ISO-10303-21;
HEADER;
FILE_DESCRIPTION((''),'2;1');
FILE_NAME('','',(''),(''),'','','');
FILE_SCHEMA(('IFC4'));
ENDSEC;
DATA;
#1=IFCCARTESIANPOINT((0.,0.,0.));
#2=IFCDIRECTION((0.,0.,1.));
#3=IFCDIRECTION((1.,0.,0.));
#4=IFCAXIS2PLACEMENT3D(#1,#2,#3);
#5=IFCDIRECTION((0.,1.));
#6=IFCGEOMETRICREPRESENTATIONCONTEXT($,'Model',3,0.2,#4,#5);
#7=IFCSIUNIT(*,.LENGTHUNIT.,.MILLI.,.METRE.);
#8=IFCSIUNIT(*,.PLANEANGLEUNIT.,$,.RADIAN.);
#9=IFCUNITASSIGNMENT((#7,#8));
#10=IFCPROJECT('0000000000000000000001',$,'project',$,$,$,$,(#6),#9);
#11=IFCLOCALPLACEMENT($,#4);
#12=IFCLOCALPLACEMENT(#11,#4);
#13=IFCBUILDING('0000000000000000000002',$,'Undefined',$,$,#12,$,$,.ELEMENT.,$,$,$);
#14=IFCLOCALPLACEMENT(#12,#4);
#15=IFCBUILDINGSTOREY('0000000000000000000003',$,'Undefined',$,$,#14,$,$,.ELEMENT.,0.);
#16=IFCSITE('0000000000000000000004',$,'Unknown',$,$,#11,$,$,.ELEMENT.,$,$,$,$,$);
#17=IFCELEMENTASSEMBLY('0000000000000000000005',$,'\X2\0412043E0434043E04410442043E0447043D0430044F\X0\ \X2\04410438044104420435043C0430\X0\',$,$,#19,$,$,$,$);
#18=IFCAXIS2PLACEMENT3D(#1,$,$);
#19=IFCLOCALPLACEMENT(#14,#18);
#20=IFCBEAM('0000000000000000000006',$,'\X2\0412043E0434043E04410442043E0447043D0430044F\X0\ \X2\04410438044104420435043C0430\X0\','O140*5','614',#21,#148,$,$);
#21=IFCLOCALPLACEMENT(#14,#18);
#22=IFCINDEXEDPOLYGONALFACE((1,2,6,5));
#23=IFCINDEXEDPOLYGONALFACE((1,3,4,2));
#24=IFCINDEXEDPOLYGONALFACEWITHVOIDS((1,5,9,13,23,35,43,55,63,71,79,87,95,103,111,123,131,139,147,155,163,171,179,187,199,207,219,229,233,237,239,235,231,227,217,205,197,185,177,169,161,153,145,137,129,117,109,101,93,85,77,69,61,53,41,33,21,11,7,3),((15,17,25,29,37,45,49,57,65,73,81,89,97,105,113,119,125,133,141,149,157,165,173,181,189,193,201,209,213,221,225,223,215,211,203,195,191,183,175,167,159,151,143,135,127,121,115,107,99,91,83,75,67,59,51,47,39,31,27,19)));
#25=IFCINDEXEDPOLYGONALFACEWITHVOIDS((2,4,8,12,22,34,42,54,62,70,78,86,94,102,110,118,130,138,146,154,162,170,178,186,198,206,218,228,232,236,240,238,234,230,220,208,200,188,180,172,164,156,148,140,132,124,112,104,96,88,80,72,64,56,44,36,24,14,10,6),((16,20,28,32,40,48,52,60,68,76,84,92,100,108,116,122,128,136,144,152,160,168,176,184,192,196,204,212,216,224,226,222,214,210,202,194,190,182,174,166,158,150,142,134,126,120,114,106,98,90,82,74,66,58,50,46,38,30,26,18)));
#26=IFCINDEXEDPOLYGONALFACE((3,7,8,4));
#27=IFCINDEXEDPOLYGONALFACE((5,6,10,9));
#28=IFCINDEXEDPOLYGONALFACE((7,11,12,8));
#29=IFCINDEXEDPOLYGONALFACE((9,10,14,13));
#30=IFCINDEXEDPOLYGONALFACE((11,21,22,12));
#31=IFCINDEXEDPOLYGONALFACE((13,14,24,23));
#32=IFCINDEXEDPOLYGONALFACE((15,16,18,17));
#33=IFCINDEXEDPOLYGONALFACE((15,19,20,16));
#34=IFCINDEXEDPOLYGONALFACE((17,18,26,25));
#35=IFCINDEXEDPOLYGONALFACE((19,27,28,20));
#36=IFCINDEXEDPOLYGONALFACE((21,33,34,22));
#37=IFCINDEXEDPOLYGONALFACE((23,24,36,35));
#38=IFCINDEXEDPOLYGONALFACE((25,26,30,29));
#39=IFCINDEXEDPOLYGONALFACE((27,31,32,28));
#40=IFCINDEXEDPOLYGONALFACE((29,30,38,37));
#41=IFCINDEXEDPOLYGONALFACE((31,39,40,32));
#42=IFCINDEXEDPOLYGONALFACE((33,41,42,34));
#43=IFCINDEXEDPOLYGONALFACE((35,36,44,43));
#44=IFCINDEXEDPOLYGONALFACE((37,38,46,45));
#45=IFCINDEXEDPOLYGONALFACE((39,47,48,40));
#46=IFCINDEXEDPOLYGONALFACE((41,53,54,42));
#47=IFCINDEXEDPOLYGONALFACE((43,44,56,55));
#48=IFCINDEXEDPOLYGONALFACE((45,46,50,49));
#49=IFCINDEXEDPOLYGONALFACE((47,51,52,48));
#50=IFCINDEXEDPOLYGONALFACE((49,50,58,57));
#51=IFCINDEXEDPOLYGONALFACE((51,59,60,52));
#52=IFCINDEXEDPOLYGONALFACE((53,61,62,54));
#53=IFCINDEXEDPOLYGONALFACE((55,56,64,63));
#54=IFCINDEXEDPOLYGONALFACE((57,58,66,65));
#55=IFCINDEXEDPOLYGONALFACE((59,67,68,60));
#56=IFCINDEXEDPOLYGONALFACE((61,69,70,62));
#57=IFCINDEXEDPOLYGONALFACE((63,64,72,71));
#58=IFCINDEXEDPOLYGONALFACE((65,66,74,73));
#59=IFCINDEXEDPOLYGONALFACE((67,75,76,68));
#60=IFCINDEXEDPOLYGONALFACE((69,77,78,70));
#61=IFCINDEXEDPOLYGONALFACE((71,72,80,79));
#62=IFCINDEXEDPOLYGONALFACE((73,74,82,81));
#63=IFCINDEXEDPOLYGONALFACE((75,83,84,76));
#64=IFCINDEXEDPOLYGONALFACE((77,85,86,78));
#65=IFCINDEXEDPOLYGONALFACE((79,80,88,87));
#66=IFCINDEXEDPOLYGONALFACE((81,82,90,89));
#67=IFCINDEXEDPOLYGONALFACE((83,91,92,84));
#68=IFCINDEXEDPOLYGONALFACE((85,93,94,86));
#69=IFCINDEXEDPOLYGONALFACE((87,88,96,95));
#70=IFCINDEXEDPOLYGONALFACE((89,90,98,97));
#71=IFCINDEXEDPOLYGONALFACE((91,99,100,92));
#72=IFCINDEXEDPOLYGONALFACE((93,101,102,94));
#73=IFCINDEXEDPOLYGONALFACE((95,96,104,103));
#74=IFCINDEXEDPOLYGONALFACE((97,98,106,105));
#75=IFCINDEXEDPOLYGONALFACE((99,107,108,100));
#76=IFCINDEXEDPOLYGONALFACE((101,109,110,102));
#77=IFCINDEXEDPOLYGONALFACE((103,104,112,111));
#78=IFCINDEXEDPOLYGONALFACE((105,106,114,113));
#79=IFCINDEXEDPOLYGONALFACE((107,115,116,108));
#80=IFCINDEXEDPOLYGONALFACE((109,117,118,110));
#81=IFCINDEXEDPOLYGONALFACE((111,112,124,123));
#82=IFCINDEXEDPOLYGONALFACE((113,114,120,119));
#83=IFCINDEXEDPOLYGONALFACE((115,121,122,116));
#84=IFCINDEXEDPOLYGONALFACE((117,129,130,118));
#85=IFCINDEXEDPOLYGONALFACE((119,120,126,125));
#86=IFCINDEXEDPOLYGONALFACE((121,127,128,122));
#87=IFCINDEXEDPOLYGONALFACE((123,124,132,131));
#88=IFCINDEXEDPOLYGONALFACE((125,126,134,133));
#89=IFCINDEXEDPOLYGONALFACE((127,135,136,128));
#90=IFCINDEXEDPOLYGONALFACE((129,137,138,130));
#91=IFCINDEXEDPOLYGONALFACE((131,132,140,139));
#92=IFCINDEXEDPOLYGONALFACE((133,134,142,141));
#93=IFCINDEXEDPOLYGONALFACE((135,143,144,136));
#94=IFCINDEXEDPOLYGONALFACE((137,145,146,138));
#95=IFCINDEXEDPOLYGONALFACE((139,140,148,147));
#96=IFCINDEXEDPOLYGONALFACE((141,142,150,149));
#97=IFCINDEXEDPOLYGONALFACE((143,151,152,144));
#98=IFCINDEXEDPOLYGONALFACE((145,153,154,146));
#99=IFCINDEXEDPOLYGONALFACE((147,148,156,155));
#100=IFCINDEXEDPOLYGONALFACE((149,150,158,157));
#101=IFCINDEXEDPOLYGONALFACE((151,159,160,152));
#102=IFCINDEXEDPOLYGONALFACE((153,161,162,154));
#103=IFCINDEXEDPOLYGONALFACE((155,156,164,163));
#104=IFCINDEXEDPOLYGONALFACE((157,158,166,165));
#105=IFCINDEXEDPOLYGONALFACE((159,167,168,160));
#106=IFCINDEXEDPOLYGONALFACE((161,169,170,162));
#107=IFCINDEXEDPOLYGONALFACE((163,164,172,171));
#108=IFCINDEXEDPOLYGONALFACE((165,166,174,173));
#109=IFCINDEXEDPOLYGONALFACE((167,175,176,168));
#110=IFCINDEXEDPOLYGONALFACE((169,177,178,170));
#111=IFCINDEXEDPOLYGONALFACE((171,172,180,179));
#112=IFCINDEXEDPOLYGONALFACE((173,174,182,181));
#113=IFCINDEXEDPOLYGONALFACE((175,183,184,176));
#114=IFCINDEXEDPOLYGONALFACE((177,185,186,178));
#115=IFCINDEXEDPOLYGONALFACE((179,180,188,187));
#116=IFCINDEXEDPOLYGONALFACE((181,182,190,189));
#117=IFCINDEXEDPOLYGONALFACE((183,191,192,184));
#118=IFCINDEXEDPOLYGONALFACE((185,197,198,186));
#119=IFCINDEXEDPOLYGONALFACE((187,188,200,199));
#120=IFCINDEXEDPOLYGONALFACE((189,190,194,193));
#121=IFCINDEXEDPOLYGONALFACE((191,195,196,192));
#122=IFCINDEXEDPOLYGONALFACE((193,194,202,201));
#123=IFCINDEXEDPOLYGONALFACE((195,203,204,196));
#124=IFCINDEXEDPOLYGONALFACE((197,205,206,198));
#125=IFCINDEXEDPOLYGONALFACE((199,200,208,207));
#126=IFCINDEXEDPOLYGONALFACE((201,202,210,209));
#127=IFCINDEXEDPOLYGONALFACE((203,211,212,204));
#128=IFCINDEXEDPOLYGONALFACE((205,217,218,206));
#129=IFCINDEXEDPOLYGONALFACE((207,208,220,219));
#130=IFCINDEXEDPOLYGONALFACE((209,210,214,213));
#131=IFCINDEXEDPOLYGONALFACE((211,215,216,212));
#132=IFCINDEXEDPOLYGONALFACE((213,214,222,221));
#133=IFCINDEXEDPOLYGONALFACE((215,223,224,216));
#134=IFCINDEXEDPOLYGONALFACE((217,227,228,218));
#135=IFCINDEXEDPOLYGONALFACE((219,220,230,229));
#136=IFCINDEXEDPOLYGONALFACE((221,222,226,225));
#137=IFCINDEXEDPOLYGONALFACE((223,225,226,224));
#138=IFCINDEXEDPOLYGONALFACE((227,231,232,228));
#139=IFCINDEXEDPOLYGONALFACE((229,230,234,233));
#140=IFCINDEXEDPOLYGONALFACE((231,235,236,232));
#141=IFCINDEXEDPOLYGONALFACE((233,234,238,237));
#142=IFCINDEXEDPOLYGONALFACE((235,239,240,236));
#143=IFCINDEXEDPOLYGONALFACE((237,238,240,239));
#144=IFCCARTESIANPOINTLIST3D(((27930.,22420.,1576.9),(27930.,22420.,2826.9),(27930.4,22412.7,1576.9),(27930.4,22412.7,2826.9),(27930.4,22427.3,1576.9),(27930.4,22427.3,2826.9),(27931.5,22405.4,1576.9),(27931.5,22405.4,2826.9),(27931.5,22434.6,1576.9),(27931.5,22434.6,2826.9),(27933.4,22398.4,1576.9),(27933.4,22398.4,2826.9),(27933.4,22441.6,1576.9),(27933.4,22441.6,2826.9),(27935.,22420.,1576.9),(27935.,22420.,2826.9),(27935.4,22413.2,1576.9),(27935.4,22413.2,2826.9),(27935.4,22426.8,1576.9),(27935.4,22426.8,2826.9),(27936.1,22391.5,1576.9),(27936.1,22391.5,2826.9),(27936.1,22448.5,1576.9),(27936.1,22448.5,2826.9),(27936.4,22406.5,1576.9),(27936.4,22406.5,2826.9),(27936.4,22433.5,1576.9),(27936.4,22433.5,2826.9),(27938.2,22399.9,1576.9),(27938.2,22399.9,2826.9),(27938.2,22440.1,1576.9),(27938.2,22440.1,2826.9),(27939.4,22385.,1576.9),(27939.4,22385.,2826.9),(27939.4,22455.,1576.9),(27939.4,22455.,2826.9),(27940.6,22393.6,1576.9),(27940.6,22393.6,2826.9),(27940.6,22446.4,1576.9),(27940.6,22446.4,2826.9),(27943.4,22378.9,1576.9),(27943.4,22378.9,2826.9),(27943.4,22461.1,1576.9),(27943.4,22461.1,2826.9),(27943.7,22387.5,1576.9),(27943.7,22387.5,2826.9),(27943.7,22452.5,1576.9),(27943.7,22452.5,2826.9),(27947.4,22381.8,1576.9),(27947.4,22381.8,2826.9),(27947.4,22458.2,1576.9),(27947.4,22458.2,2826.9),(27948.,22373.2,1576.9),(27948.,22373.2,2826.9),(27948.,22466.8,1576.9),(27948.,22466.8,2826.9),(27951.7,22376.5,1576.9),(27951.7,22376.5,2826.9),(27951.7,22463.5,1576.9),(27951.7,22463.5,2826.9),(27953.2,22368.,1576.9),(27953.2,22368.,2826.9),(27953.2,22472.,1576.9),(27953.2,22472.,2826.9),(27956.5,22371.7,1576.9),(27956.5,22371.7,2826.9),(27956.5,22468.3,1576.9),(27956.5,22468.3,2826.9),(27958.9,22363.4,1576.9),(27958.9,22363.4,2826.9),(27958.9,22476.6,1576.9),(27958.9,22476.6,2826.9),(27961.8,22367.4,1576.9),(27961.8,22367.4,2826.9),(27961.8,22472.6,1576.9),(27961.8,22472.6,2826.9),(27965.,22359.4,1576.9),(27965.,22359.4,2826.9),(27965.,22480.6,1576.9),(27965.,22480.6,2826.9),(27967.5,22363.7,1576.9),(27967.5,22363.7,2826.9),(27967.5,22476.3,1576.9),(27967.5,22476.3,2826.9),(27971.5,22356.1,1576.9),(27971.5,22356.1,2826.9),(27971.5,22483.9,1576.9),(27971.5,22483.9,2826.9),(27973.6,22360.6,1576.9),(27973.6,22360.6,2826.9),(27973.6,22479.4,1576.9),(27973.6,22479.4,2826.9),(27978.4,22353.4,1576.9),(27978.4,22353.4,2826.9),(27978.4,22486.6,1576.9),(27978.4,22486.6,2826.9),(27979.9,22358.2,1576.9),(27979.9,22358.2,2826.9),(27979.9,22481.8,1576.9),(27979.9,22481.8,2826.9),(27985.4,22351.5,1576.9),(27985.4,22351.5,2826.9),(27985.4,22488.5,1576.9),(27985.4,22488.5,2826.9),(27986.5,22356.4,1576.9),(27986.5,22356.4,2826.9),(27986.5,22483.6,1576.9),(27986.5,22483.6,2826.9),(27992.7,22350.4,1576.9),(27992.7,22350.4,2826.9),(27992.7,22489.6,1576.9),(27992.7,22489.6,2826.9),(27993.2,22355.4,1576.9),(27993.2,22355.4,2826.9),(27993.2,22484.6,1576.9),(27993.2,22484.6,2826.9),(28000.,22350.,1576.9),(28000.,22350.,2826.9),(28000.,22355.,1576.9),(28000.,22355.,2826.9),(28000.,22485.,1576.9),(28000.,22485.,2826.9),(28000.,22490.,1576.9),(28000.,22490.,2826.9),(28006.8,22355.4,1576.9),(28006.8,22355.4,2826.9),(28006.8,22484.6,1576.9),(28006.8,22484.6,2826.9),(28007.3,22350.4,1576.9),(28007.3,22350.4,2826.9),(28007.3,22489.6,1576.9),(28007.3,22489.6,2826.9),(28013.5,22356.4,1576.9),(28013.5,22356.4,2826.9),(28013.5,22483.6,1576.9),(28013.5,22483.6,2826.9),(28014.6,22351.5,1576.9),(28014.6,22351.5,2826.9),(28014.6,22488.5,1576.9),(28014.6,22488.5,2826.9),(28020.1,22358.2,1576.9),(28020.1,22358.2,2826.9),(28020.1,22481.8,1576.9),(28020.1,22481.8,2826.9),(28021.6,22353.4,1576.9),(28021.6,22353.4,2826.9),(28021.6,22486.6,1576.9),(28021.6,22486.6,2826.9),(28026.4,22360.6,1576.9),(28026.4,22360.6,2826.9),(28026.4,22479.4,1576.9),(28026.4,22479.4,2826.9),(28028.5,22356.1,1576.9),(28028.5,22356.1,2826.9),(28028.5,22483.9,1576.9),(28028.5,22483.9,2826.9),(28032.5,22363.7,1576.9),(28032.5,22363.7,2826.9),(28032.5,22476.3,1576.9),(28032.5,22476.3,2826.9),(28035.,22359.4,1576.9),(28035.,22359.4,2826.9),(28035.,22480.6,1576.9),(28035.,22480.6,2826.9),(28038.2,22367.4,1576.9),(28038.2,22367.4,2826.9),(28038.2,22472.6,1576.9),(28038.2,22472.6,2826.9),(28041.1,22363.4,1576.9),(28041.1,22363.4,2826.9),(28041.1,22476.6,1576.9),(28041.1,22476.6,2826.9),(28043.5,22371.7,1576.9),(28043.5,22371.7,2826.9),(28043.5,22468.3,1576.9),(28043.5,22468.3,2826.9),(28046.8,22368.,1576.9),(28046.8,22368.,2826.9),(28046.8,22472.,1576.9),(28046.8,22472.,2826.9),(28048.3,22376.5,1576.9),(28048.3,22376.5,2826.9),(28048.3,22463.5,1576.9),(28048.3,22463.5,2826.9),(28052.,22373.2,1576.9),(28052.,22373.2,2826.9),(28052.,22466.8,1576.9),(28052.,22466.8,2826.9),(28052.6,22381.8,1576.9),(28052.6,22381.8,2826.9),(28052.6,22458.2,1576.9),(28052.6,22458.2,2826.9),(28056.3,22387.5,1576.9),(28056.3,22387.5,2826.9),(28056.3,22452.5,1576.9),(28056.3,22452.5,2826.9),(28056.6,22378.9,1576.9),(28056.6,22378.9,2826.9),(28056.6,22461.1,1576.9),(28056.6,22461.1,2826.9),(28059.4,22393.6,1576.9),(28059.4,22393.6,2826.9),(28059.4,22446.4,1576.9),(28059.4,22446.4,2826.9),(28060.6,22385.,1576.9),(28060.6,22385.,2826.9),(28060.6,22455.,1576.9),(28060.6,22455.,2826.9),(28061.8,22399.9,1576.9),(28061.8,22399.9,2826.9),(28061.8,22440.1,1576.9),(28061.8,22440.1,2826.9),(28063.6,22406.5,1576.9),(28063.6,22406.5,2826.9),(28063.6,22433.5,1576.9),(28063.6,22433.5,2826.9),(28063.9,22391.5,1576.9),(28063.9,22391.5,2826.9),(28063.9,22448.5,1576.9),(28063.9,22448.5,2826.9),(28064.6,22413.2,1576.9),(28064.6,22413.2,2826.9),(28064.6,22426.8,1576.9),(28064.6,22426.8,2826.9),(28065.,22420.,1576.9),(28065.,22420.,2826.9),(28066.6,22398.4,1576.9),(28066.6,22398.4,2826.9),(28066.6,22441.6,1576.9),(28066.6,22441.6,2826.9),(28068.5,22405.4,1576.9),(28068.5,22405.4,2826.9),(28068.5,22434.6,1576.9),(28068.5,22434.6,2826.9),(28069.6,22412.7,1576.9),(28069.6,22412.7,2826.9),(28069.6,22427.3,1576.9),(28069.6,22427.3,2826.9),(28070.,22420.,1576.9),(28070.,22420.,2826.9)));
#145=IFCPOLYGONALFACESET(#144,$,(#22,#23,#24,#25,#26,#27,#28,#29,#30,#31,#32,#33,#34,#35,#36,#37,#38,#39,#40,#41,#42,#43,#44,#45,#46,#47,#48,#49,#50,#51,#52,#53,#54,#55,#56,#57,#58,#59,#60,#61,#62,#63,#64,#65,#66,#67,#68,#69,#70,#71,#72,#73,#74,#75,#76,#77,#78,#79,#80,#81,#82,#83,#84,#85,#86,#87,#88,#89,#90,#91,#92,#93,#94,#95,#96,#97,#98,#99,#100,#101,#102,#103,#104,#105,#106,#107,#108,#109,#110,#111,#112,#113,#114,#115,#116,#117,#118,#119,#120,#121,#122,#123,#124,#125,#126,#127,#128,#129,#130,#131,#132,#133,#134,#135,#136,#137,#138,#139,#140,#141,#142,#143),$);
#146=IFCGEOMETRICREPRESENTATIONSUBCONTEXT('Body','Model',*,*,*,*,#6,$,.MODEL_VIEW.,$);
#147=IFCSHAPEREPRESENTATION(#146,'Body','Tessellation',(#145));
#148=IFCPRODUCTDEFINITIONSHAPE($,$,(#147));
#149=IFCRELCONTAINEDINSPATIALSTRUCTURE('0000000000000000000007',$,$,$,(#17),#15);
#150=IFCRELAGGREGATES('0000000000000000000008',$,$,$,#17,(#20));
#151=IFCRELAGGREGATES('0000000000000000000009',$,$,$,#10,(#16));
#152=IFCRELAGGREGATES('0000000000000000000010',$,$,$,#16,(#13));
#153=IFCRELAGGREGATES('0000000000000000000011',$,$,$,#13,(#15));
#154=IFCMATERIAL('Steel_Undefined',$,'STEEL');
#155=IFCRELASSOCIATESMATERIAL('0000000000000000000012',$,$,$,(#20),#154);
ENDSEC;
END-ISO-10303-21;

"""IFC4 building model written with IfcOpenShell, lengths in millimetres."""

from ifc_helpers import new_model, si_unit, direction, frame, origin_with_axes, place, context, subcontext, project, spatial, line, indexed_curve, outline, extrude, material, element, aggregate, save


model = new_model("IFC4")

# Units and contexts
model_context = context("Model", 3, precision=0.2, world=origin_with_axes(), true_north=direction((0.0, 1.0)))
body_context = subcontext(model_context, "Body", "Model", "MODEL_VIEW")
ifc_project = project(units=[si_unit("LENGTHUNIT", "METRE", prefix="MILLI"), si_unit("PLANEANGLEUNIT", "RADIAN")], contexts=[model_context])

# Site, building, storey
site_placement = place(None, origin_with_axes())
site = spatial("IfcSite", under=ifc_project, at=site_placement, Name="Unknown", CompositionType="ELEMENT")
building_placement = place(site_placement, origin_with_axes())
building = spatial("IfcBuilding", under=site, at=building_placement, Name="Undefined", CompositionType="ELEMENT")
storey_placement = place(building_placement, origin_with_axes())
storey = spatial("IfcBuildingStorey", under=building, at=storey_placement, Name="Undefined", CompositionType="ELEMENT", Elevation=0.0)

# Element assembly, beam
assembly_1_placement = place(storey_placement, frame((28000.0, 22420.0, 2826.9), z_axis=(0.0, -1.0, 0.0), x_axis=(0.0, 0.0, -1.0)))
assembly_1 = element("IfcElementAssembly", 1, at=assembly_1_placement, inside=storey, Name="Водосточная система")
ifc_material_1 = material(Name="Steel_Undefined", Category="STEEL")
beam_1_placement = place(assembly_1_placement, origin_with_axes())
beam_1 = element("IfcBeam", 2, at=beam_1_placement, material=ifc_material_1, Name="Водосточная система", Description="O140*5", ObjectType="614", context=body_context, shape_type="SolidModel", body=[
    extrude(outline(indexed_curve([(70.0, 0.0), (69.6, 7.3), (68.5, 14.6), (66.6, 21.6), (63.9, 28.5), (60.6, 35.0), (56.6, 41.1), (52.0, 46.8), (46.8, 52.0), (41.1, 56.6), (35.0, 60.6), (28.5, 63.9), (21.6, 66.6), (14.6, 68.5), (7.3, 69.6), (0.0, 70.0), (-7.3, 69.6), (-14.6, 68.5), (-21.6, 66.6), (-28.5, 63.9), (-35.0, 60.6), (-41.1, 56.6), (-46.8, 52.0), (-52.0, 46.8), (-56.6, 41.1), (-60.6, 35.0), (-63.9, 28.5), (-66.6, 21.6), (-68.5, 14.6), (-69.6, 7.3), (-70.0, 0.0), (-69.6, -7.3), (-68.5, -14.6), (-66.6, -21.6), (-63.9, -28.5), (-60.6, -35.0), (-56.6, -41.1), (-52.0, -46.8), (-46.8, -52.0), (-41.1, -56.6), (-35.0, -60.6), (-28.5, -63.9), (-21.6, -66.6), (-14.6, -68.5), (-7.3, -69.6), (0.0, -70.0), (7.3, -69.6), (14.6, -68.5), (21.6, -66.6), (28.5, -63.9), (35.0, -60.6), (41.1, -56.6), (46.8, -52.0), (52.0, -46.8), (56.6, -41.1), (60.6, -35.0), (63.9, -28.5), (66.6, -21.6), (68.5, -14.6), (69.6, -7.3)], segments=[line(1, 2, 3, 4, 5, 6, 7, 8, 9, 10, 11, 12, 13, 14, 15, 16, 17, 18, 19, 20, 21, 22, 23, 24, 25, 26, 27, 28, 29, 30, 31, 32, 33, 34, 35, 36, 37, 38, 39, 40, 41, 42, 43, 44, 45, 46, 47, 48, 49, 50, 51, 52, 53, 54, 55, 56, 57, 58, 59, 60, 1)]), holes=[indexed_curve([(65.0, 0.0), (64.6, -6.8), (63.6, -13.5), (61.8, -20.1), (59.4, -26.4), (56.3, -32.5), (52.6, -38.2), (48.3, -43.5), (43.5, -48.3), (38.2, -52.6), (32.5, -56.3), (26.4, -59.4), (20.1, -61.8), (13.5, -63.6), (6.8, -64.6), (0.0, -65.0), (-6.8, -64.6), (-13.5, -63.6), (-20.1, -61.8), (-26.4, -59.4), (-32.5, -56.3), (-38.2, -52.6), (-43.5, -48.3), (-48.3, -43.5), (-52.6, -38.2), (-56.3, -32.5), (-59.4, -26.4), (-61.8, -20.1), (-63.6, -13.5), (-64.6, -6.8), (-65.0, 0.0), (-64.6, 6.8), (-63.6, 13.5), (-61.8, 20.1), (-59.4, 26.4), (-56.3, 32.5), (-52.6, 38.2), (-48.3, 43.5), (-43.5, 48.3), (-38.2, 52.6), (-32.5, 56.3), (-26.4, 59.4), (-20.1, 61.8), (-13.5, 63.6), (-6.8, 64.6), (0.0, 65.0), (6.8, 64.6), (13.5, 63.6), (20.1, 61.8), (26.4, 59.4), (32.5, 56.3), (38.2, 52.6), (43.5, 48.3), (48.3, 43.5), (52.6, 38.2), (56.3, 32.5), (59.4, 26.4), (61.8, 20.1), (63.6, 13.5), (64.6, 6.8)], segments=[line(1, 2, 3, 4, 5, 6, 7, 8, 9, 10, 11, 12, 13, 14, 15, 16, 17, 18, 19, 20, 21, 22, 23, 24, 25, 26, 27, 28, 29, 30, 31, 32, 33, 34, 35, 36, 37, 38, 39, 40, 41, 42, 43, 44, 45, 46, 47, 48, 49, 50, 51, 52, 53, 54, 55, 56, 57, 58, 59, 60, 1)])]), frame((0.0, 0.0, 0.0), z_axis=(-1.0, 0.0, 0.0), x_axis=(0.0, 0.0, 1.0)), (0.0, 0.0, -1.0), 1250.0),
])
aggregate(assembly_1, [beam_1])

save(model, "model.ifc")
